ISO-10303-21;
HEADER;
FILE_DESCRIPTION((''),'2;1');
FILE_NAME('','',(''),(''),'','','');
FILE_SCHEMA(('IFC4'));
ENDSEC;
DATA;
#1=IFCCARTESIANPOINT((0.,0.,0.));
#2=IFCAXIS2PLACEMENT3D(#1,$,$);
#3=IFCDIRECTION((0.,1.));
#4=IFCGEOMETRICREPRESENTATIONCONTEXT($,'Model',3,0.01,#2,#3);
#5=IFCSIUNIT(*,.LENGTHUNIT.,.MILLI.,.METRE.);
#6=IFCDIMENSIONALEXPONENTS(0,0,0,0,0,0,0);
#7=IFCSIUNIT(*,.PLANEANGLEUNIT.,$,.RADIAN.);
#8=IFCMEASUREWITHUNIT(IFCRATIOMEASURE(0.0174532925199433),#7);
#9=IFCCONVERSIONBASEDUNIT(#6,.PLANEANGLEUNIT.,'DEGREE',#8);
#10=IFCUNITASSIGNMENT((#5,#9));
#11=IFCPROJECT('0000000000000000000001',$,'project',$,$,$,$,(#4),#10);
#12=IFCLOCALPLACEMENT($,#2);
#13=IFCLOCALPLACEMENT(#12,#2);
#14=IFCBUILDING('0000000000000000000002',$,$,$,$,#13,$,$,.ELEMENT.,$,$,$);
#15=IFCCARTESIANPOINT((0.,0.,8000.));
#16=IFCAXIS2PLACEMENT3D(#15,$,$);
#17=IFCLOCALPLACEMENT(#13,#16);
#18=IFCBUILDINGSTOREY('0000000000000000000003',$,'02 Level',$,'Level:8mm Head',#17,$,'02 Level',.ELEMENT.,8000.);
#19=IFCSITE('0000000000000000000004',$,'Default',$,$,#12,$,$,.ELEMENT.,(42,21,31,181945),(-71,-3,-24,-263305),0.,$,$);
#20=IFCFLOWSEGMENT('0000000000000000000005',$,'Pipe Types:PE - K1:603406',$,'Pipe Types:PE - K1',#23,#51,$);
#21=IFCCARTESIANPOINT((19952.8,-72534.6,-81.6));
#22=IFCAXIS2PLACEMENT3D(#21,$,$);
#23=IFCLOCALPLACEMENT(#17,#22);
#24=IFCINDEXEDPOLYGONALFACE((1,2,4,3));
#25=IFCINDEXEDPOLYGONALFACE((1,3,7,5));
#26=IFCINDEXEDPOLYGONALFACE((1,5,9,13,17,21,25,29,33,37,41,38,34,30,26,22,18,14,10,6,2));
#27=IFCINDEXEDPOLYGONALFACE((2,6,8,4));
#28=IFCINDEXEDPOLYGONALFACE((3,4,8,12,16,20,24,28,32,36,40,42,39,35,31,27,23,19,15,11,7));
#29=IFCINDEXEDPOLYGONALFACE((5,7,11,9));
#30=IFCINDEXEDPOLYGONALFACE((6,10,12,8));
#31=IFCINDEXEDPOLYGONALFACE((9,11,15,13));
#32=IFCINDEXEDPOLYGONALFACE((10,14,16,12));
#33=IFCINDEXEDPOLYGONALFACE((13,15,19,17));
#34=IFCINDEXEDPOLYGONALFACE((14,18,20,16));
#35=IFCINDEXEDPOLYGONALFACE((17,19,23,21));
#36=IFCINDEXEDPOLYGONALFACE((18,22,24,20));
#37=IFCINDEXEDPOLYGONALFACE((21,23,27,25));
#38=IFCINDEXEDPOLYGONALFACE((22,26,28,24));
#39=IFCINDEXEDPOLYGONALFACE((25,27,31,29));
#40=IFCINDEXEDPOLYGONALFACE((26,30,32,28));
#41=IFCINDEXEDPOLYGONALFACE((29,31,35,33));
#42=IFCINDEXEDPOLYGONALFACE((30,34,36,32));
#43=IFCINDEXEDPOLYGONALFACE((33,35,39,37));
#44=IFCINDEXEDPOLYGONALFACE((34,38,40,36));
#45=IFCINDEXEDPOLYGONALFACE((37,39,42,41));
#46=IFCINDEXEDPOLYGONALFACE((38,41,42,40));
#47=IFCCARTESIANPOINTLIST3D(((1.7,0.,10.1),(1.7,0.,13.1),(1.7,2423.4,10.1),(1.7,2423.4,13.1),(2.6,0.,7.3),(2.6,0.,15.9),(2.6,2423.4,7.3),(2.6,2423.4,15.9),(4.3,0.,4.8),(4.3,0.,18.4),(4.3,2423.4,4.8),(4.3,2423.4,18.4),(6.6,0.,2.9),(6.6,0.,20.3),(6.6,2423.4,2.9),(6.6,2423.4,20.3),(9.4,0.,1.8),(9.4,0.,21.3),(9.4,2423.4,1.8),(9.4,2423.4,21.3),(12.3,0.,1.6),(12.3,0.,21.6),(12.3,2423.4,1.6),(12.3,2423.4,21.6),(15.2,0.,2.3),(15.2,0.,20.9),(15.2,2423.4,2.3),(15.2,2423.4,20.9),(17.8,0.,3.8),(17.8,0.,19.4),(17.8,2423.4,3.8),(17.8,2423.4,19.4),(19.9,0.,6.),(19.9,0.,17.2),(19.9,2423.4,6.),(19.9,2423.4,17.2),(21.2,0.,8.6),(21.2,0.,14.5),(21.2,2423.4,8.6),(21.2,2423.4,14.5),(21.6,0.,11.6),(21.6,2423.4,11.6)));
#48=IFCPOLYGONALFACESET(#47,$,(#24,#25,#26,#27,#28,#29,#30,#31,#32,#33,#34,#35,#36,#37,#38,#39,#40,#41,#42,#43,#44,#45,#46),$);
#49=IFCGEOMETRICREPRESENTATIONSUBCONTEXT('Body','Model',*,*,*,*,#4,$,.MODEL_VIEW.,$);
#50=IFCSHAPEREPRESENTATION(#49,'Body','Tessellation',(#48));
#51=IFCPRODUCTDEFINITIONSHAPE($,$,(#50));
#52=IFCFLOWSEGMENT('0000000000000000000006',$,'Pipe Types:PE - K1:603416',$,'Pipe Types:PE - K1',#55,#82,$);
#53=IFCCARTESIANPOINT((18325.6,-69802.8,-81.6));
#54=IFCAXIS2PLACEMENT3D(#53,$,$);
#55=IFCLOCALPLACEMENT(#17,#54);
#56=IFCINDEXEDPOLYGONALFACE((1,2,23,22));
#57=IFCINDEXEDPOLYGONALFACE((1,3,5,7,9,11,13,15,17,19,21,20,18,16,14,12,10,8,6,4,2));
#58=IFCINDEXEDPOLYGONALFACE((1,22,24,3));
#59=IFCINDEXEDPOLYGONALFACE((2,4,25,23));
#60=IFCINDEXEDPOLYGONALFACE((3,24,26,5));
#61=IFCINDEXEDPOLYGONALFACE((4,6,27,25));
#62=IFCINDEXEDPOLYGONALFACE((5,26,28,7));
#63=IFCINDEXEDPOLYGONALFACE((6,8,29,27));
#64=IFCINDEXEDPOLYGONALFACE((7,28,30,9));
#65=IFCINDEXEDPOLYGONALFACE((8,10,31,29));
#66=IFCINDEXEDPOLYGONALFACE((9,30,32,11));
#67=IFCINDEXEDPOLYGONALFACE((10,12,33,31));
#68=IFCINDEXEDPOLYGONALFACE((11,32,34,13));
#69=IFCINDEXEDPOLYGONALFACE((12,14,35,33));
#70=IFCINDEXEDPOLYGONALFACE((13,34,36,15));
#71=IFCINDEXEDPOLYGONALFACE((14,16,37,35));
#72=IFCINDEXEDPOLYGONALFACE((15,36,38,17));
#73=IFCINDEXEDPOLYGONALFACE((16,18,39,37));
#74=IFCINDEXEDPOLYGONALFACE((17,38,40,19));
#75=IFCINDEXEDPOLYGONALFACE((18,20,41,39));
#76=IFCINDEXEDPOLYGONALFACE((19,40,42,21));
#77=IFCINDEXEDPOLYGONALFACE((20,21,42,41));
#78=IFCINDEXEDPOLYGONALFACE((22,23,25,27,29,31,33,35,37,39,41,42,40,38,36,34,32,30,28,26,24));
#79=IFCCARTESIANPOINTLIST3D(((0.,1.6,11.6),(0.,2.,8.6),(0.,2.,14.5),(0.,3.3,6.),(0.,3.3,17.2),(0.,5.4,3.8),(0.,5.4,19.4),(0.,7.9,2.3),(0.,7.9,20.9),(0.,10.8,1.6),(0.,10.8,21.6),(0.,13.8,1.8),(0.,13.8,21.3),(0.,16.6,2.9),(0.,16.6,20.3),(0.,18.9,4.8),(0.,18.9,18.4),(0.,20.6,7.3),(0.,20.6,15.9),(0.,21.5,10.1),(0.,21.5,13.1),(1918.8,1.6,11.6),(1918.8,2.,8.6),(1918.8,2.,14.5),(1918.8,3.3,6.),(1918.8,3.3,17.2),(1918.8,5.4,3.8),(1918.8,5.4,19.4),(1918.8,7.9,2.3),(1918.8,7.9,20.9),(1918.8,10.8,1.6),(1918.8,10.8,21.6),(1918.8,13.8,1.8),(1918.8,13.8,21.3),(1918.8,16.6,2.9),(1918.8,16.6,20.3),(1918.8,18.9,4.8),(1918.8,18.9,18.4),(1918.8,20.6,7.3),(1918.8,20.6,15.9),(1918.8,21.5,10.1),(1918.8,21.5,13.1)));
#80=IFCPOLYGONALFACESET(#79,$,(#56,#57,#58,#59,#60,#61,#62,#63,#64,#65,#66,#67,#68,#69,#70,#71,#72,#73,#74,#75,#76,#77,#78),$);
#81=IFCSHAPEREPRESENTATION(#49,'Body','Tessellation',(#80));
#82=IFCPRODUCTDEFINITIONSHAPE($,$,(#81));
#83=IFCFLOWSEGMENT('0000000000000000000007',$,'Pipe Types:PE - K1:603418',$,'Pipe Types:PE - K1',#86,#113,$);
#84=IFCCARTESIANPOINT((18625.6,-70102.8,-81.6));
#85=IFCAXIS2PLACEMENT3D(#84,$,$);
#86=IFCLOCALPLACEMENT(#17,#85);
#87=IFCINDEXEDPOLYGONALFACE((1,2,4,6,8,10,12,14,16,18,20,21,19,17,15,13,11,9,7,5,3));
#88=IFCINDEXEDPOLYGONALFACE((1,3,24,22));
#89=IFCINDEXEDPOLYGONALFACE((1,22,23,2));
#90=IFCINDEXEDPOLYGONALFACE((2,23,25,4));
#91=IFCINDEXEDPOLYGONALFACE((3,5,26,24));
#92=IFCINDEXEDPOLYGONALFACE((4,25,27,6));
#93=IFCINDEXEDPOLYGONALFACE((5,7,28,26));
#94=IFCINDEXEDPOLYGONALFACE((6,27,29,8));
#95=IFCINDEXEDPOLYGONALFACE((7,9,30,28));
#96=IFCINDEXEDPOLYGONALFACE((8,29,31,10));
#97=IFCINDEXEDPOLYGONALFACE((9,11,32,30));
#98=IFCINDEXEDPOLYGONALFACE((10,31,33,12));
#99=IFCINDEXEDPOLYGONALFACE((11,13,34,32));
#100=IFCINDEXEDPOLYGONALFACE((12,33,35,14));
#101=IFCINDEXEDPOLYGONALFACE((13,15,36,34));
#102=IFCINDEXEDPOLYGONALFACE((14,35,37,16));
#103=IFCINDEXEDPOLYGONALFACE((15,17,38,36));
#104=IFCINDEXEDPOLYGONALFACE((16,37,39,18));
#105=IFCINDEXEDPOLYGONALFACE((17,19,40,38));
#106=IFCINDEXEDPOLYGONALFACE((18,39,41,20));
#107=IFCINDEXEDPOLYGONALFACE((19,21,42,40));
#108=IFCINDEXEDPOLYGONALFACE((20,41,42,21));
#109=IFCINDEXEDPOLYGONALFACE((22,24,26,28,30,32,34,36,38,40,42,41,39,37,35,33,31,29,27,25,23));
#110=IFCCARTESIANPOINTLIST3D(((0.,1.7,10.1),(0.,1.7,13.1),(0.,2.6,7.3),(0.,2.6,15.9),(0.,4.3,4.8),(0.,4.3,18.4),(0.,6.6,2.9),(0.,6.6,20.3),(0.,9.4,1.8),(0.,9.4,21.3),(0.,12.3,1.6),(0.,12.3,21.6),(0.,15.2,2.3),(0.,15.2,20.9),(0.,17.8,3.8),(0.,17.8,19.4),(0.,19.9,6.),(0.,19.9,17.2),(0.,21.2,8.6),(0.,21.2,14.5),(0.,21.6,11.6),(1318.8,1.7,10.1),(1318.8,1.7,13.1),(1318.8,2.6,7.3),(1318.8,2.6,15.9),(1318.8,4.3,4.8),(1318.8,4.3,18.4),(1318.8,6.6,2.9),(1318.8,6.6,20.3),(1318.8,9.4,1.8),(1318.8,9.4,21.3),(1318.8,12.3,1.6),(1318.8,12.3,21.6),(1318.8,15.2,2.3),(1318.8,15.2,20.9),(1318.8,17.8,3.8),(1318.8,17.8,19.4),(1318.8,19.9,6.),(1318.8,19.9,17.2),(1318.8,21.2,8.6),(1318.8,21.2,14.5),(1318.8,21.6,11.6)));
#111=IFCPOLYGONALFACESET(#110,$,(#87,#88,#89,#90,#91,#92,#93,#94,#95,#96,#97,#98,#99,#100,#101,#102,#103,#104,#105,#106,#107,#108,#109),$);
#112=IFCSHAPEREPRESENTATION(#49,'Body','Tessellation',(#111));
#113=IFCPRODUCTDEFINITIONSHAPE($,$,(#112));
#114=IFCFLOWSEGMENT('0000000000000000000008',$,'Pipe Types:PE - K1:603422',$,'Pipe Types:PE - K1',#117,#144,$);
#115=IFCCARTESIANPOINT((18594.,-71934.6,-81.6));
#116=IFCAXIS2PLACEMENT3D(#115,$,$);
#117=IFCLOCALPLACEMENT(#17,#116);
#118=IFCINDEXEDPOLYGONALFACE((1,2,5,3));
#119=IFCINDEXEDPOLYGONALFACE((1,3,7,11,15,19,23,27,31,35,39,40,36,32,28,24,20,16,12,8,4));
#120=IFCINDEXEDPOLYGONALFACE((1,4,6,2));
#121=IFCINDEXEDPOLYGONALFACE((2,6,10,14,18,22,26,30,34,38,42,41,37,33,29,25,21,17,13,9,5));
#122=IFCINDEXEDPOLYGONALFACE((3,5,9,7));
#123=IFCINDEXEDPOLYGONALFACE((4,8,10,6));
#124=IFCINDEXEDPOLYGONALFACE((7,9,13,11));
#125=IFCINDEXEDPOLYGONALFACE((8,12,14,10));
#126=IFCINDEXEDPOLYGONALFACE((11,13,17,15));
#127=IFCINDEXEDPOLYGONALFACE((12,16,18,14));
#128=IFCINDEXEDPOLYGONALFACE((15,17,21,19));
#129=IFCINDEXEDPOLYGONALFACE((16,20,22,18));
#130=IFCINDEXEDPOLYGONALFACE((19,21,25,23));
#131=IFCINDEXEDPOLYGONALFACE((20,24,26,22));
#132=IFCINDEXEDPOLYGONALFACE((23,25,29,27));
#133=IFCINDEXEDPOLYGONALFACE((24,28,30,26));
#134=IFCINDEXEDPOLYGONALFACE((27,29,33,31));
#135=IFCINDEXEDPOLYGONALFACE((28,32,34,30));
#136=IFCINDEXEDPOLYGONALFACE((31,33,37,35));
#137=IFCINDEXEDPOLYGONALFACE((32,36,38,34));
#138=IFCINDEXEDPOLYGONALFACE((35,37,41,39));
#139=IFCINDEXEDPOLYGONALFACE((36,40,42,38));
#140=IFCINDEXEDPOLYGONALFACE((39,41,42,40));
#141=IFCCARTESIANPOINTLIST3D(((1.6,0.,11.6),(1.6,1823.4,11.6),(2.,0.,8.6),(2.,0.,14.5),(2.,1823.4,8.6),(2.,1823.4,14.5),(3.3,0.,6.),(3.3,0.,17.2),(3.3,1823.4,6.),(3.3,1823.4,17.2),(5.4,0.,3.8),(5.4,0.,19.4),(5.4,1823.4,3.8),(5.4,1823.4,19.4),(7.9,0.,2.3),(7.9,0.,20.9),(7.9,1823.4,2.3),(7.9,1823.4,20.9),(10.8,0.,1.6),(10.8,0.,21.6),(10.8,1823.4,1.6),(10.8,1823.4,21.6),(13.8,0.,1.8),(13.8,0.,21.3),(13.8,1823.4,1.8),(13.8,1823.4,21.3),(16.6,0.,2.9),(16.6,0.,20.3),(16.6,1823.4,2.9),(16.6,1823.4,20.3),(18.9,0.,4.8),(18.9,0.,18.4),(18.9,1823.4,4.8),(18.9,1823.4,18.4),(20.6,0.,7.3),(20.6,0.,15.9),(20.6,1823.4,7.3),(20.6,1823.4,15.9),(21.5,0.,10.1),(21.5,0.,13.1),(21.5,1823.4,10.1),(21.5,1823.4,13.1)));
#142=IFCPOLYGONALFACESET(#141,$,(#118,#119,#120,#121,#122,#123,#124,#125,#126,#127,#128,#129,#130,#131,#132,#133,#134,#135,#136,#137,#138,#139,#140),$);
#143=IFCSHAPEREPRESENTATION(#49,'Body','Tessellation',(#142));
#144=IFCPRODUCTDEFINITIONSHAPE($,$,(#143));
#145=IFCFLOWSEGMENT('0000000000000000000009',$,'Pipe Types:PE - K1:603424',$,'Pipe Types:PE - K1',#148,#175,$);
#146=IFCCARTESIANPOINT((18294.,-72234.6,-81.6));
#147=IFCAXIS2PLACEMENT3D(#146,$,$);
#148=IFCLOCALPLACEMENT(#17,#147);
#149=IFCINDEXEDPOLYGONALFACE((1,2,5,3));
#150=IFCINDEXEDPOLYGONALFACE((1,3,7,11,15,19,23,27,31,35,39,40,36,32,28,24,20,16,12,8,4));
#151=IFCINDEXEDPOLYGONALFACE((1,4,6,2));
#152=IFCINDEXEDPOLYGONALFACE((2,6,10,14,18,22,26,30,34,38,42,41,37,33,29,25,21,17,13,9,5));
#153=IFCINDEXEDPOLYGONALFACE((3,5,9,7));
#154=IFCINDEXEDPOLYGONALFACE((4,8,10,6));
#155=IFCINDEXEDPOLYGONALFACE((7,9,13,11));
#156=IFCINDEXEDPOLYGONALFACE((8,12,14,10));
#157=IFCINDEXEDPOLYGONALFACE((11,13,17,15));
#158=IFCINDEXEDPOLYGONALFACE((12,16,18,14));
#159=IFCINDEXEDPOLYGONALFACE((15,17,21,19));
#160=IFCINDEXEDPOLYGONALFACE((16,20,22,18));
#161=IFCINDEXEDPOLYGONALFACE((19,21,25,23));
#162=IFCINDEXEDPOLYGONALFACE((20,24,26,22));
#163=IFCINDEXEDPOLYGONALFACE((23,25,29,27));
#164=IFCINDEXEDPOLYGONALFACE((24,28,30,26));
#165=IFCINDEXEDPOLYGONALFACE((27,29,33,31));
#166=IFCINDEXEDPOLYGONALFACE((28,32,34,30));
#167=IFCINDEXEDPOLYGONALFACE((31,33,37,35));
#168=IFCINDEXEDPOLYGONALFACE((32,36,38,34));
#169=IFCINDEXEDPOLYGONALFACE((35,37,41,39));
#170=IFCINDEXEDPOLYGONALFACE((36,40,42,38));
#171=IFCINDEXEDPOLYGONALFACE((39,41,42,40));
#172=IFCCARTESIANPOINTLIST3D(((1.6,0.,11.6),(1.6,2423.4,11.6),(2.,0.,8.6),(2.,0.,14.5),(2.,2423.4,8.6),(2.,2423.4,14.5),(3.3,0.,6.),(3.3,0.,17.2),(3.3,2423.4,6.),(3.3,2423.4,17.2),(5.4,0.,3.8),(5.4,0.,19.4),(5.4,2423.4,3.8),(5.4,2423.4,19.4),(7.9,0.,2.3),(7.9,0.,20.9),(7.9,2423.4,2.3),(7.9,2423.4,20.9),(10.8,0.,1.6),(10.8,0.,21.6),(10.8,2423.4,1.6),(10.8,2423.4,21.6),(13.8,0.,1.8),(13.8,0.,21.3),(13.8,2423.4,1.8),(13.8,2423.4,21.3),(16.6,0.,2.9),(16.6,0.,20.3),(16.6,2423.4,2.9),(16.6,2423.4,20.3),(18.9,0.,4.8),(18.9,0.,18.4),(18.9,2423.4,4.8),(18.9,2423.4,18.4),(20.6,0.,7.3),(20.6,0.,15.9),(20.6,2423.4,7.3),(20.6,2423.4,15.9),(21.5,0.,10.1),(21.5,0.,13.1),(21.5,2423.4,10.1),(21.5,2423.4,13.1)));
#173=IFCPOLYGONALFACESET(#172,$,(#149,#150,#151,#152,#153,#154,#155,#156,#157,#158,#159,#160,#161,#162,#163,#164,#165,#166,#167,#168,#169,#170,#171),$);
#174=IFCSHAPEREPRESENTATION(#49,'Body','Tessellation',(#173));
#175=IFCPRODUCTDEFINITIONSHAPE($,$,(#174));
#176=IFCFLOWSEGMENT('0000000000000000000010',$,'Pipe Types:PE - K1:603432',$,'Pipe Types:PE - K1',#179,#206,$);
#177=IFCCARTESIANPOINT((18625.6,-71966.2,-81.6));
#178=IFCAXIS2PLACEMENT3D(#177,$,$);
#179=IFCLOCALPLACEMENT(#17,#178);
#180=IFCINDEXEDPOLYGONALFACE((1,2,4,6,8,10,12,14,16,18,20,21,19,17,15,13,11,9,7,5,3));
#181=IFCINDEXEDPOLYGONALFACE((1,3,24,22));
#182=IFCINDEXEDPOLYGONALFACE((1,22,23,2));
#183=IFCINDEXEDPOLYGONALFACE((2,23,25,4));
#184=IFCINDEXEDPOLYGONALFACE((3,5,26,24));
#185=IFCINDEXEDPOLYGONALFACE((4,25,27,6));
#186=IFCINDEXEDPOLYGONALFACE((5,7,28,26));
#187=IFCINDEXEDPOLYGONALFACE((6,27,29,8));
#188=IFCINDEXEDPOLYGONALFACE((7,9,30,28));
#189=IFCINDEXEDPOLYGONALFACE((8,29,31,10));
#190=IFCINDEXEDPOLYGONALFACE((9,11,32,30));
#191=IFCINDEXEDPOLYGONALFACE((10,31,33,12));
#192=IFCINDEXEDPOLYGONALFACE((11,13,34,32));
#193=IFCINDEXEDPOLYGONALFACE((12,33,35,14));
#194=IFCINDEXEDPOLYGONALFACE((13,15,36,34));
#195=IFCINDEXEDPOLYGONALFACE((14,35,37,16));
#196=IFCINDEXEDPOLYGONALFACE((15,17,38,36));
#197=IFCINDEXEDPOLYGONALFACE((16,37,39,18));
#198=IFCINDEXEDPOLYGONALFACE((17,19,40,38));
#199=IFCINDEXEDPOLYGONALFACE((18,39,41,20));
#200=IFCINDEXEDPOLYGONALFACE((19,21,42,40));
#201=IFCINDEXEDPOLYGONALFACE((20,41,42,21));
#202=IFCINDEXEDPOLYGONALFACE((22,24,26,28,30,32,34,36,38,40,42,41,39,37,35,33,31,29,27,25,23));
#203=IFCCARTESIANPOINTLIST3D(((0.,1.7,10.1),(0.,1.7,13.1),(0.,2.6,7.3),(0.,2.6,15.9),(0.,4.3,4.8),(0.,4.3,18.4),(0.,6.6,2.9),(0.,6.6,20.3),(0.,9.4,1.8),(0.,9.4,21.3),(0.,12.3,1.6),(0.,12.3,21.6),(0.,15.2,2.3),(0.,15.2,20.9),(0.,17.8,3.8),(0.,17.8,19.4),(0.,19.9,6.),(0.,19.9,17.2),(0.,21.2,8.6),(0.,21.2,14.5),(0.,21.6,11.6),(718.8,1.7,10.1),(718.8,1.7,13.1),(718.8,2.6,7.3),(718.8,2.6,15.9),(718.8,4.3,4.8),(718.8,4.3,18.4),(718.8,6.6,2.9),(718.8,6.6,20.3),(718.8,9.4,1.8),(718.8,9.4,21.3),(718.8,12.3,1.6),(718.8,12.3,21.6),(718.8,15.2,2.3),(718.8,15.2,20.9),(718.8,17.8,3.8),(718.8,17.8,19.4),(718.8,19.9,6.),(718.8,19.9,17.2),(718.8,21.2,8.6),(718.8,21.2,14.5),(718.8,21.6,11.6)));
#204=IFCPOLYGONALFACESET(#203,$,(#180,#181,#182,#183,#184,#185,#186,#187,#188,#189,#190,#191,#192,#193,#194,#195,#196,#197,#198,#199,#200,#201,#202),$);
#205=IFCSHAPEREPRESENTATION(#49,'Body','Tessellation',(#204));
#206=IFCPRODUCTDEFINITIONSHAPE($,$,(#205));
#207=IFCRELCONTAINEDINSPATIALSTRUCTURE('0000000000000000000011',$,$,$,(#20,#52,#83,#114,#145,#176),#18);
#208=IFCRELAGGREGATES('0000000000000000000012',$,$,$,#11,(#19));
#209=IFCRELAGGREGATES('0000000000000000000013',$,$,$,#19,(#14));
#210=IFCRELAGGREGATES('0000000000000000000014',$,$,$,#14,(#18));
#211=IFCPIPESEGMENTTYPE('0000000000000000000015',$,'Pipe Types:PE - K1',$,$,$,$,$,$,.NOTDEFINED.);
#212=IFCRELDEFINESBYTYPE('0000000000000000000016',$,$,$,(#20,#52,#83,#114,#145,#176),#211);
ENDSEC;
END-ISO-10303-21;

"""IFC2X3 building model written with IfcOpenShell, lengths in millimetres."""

from ifc_helpers import new_model, entity, si_unit, converted_unit, direction, frame, frame_2d, origin, origin_2d_with_axis, place, context, subcontext, project, spatial, circle, extrude, type_object, element, save


model = new_model("IFC2X3")

# Units and contexts
model_context = context("Model", 3, precision=0.01, world=origin(), true_north=direction((0.0, 1.0)))
body_context = subcontext(model_context, "Body", "Model", "MODEL_VIEW")
ifc_project = project(units=[si_unit("LENGTHUNIT", "METRE", prefix="MILLI"), converted_unit("PLANEANGLEUNIT", "DEGREE", entity("IfcRatioMeasure", 0.0174532925199433), si_unit("PLANEANGLEUNIT", "RADIAN"), dimensions=[0, 0, 0, 0, 0, 0, 0])], contexts=[model_context])

# Site, building, storey
site_placement = place(None, origin())
site = spatial("IfcSite", under=ifc_project, at=site_placement, Name="Default", CompositionType="ELEMENT", RefLatitude=(42, 21, 31, 181945), RefLongitude=(-71, -3, -24, -263305), RefElevation=0.0)
building_placement = place(site_placement, origin())
building = spatial("IfcBuilding", under=site, at=building_placement, CompositionType="ELEMENT")
storey_placement = place(building_placement, frame((0.0, 0.0, 8000.0)))
storey = spatial("IfcBuildingStorey", under=building, at=storey_placement, Name="02 Level", ObjectType="Level:8mm Head", LongName="02 Level", CompositionType="ELEMENT", Elevation=8000.0)

# Flow segments
pipe_segment_type = type_object("IfcPipeSegmentType", Name="Pipe Types:PE - K1", PredefinedType="NOTDEFINED")
flow_segment_1_placement = place(storey_placement, frame((19952.8, -72534.6, -81.6)))
element("IfcFlowSegment", 1, at=flow_segment_1_placement, inside=storey, type_object=pipe_segment_type, Name="Pipe Types:PE - K1:603406", ObjectType="Pipe Types:PE - K1", context=body_context, shape_type="SweptSolid", body=[
    extrude(circle(Radius=10.0, at=origin_2d_with_axis()), frame((11.6, 0.0, 11.6), z_axis=(0.0, 1.0, 0.0), x_axis=(1.0, 0.0, 0.0)), (0.0, 0.0, 1.0), 2423.4),
])
flow_segment_2_placement = place(storey_placement, frame((18325.6, -69802.8, -81.6)))
element("IfcFlowSegment", 2, at=flow_segment_2_placement, inside=storey, type_object=pipe_segment_type, Name="Pipe Types:PE - K1:603416", ObjectType="Pipe Types:PE - K1", context=body_context, shape_type="SweptSolid", body=[
    extrude(circle(Radius=10.0, at=origin_2d_with_axis()), frame((0.0, 11.6, 11.6), z_axis=(1.0, 0.0, 0.0), x_axis=(0.0, -1.0, 0.0)), (0.0, 0.0, 1.0), 1918.8),
])
flow_segment_3_placement = place(storey_placement, frame((18625.6, -70102.8, -81.6)))
element("IfcFlowSegment", 3, at=flow_segment_3_placement, inside=storey, type_object=pipe_segment_type, Name="Pipe Types:PE - K1:603418", ObjectType="Pipe Types:PE - K1", context=body_context, shape_type="SweptSolid", body=[
    extrude(circle(Radius=10.0, at=frame_2d((0.0, 0.0), x_axis=(1.0, 0.0))), frame((0.0, 11.6, 11.6), z_axis=(1.0, 0.0, 0.0), x_axis=(0.0, 1.0, 0.0)), (0.0, 0.0, 1.0), 1318.8),
])
flow_segment_4_placement = place(storey_placement, frame((18594.0, -71934.6, -81.6)))
element("IfcFlowSegment", 4, at=flow_segment_4_placement, inside=storey, type_object=pipe_segment_type, Name="Pipe Types:PE - K1:603422", ObjectType="Pipe Types:PE - K1", context=body_context, shape_type="SweptSolid", body=[
    extrude(circle(Radius=10.0, at=frame_2d((0.0, 0.0), x_axis=(1.0, 0.0))), frame((11.6, 0.0, 11.6), z_axis=(0.0, 1.0, 0.0), x_axis=(-1.0, 0.0, 0.0)), (0.0, 0.0, 1.0), 1823.4),
])
flow_segment_5_placement = place(storey_placement, frame((18294.0, -72234.6, -81.6)))
element("IfcFlowSegment", 5, at=flow_segment_5_placement, inside=storey, type_object=pipe_segment_type, Name="Pipe Types:PE - K1:603424", ObjectType="Pipe Types:PE - K1", context=body_context, shape_type="SweptSolid", body=[
    extrude(circle(Radius=10.0, at=frame_2d((0.0, 0.0), x_axis=(1.0, 0.0))), frame((11.6, 0.0, 11.6), z_axis=(0.0, 1.0, 0.0), x_axis=(-1.0, 0.0, 0.0)), (0.0, 0.0, 1.0), 2423.4),
])
flow_segment_6_placement = place(storey_placement, frame((18625.6, -71966.2, -81.6)))
element("IfcFlowSegment", 6, at=flow_segment_6_placement, inside=storey, type_object=pipe_segment_type, Name="Pipe Types:PE - K1:603432", ObjectType="Pipe Types:PE - K1", context=body_context, shape_type="SweptSolid", body=[
    extrude(circle(Radius=10.0, at=origin_2d_with_axis()), frame((0.0, 11.6, 11.6), z_axis=(1.0, 0.0, 0.0), x_axis=(0.0, 1.0, 0.0)), (0.0, 0.0, 1.0), 718.8),
])

save(model, "model.ifc")
